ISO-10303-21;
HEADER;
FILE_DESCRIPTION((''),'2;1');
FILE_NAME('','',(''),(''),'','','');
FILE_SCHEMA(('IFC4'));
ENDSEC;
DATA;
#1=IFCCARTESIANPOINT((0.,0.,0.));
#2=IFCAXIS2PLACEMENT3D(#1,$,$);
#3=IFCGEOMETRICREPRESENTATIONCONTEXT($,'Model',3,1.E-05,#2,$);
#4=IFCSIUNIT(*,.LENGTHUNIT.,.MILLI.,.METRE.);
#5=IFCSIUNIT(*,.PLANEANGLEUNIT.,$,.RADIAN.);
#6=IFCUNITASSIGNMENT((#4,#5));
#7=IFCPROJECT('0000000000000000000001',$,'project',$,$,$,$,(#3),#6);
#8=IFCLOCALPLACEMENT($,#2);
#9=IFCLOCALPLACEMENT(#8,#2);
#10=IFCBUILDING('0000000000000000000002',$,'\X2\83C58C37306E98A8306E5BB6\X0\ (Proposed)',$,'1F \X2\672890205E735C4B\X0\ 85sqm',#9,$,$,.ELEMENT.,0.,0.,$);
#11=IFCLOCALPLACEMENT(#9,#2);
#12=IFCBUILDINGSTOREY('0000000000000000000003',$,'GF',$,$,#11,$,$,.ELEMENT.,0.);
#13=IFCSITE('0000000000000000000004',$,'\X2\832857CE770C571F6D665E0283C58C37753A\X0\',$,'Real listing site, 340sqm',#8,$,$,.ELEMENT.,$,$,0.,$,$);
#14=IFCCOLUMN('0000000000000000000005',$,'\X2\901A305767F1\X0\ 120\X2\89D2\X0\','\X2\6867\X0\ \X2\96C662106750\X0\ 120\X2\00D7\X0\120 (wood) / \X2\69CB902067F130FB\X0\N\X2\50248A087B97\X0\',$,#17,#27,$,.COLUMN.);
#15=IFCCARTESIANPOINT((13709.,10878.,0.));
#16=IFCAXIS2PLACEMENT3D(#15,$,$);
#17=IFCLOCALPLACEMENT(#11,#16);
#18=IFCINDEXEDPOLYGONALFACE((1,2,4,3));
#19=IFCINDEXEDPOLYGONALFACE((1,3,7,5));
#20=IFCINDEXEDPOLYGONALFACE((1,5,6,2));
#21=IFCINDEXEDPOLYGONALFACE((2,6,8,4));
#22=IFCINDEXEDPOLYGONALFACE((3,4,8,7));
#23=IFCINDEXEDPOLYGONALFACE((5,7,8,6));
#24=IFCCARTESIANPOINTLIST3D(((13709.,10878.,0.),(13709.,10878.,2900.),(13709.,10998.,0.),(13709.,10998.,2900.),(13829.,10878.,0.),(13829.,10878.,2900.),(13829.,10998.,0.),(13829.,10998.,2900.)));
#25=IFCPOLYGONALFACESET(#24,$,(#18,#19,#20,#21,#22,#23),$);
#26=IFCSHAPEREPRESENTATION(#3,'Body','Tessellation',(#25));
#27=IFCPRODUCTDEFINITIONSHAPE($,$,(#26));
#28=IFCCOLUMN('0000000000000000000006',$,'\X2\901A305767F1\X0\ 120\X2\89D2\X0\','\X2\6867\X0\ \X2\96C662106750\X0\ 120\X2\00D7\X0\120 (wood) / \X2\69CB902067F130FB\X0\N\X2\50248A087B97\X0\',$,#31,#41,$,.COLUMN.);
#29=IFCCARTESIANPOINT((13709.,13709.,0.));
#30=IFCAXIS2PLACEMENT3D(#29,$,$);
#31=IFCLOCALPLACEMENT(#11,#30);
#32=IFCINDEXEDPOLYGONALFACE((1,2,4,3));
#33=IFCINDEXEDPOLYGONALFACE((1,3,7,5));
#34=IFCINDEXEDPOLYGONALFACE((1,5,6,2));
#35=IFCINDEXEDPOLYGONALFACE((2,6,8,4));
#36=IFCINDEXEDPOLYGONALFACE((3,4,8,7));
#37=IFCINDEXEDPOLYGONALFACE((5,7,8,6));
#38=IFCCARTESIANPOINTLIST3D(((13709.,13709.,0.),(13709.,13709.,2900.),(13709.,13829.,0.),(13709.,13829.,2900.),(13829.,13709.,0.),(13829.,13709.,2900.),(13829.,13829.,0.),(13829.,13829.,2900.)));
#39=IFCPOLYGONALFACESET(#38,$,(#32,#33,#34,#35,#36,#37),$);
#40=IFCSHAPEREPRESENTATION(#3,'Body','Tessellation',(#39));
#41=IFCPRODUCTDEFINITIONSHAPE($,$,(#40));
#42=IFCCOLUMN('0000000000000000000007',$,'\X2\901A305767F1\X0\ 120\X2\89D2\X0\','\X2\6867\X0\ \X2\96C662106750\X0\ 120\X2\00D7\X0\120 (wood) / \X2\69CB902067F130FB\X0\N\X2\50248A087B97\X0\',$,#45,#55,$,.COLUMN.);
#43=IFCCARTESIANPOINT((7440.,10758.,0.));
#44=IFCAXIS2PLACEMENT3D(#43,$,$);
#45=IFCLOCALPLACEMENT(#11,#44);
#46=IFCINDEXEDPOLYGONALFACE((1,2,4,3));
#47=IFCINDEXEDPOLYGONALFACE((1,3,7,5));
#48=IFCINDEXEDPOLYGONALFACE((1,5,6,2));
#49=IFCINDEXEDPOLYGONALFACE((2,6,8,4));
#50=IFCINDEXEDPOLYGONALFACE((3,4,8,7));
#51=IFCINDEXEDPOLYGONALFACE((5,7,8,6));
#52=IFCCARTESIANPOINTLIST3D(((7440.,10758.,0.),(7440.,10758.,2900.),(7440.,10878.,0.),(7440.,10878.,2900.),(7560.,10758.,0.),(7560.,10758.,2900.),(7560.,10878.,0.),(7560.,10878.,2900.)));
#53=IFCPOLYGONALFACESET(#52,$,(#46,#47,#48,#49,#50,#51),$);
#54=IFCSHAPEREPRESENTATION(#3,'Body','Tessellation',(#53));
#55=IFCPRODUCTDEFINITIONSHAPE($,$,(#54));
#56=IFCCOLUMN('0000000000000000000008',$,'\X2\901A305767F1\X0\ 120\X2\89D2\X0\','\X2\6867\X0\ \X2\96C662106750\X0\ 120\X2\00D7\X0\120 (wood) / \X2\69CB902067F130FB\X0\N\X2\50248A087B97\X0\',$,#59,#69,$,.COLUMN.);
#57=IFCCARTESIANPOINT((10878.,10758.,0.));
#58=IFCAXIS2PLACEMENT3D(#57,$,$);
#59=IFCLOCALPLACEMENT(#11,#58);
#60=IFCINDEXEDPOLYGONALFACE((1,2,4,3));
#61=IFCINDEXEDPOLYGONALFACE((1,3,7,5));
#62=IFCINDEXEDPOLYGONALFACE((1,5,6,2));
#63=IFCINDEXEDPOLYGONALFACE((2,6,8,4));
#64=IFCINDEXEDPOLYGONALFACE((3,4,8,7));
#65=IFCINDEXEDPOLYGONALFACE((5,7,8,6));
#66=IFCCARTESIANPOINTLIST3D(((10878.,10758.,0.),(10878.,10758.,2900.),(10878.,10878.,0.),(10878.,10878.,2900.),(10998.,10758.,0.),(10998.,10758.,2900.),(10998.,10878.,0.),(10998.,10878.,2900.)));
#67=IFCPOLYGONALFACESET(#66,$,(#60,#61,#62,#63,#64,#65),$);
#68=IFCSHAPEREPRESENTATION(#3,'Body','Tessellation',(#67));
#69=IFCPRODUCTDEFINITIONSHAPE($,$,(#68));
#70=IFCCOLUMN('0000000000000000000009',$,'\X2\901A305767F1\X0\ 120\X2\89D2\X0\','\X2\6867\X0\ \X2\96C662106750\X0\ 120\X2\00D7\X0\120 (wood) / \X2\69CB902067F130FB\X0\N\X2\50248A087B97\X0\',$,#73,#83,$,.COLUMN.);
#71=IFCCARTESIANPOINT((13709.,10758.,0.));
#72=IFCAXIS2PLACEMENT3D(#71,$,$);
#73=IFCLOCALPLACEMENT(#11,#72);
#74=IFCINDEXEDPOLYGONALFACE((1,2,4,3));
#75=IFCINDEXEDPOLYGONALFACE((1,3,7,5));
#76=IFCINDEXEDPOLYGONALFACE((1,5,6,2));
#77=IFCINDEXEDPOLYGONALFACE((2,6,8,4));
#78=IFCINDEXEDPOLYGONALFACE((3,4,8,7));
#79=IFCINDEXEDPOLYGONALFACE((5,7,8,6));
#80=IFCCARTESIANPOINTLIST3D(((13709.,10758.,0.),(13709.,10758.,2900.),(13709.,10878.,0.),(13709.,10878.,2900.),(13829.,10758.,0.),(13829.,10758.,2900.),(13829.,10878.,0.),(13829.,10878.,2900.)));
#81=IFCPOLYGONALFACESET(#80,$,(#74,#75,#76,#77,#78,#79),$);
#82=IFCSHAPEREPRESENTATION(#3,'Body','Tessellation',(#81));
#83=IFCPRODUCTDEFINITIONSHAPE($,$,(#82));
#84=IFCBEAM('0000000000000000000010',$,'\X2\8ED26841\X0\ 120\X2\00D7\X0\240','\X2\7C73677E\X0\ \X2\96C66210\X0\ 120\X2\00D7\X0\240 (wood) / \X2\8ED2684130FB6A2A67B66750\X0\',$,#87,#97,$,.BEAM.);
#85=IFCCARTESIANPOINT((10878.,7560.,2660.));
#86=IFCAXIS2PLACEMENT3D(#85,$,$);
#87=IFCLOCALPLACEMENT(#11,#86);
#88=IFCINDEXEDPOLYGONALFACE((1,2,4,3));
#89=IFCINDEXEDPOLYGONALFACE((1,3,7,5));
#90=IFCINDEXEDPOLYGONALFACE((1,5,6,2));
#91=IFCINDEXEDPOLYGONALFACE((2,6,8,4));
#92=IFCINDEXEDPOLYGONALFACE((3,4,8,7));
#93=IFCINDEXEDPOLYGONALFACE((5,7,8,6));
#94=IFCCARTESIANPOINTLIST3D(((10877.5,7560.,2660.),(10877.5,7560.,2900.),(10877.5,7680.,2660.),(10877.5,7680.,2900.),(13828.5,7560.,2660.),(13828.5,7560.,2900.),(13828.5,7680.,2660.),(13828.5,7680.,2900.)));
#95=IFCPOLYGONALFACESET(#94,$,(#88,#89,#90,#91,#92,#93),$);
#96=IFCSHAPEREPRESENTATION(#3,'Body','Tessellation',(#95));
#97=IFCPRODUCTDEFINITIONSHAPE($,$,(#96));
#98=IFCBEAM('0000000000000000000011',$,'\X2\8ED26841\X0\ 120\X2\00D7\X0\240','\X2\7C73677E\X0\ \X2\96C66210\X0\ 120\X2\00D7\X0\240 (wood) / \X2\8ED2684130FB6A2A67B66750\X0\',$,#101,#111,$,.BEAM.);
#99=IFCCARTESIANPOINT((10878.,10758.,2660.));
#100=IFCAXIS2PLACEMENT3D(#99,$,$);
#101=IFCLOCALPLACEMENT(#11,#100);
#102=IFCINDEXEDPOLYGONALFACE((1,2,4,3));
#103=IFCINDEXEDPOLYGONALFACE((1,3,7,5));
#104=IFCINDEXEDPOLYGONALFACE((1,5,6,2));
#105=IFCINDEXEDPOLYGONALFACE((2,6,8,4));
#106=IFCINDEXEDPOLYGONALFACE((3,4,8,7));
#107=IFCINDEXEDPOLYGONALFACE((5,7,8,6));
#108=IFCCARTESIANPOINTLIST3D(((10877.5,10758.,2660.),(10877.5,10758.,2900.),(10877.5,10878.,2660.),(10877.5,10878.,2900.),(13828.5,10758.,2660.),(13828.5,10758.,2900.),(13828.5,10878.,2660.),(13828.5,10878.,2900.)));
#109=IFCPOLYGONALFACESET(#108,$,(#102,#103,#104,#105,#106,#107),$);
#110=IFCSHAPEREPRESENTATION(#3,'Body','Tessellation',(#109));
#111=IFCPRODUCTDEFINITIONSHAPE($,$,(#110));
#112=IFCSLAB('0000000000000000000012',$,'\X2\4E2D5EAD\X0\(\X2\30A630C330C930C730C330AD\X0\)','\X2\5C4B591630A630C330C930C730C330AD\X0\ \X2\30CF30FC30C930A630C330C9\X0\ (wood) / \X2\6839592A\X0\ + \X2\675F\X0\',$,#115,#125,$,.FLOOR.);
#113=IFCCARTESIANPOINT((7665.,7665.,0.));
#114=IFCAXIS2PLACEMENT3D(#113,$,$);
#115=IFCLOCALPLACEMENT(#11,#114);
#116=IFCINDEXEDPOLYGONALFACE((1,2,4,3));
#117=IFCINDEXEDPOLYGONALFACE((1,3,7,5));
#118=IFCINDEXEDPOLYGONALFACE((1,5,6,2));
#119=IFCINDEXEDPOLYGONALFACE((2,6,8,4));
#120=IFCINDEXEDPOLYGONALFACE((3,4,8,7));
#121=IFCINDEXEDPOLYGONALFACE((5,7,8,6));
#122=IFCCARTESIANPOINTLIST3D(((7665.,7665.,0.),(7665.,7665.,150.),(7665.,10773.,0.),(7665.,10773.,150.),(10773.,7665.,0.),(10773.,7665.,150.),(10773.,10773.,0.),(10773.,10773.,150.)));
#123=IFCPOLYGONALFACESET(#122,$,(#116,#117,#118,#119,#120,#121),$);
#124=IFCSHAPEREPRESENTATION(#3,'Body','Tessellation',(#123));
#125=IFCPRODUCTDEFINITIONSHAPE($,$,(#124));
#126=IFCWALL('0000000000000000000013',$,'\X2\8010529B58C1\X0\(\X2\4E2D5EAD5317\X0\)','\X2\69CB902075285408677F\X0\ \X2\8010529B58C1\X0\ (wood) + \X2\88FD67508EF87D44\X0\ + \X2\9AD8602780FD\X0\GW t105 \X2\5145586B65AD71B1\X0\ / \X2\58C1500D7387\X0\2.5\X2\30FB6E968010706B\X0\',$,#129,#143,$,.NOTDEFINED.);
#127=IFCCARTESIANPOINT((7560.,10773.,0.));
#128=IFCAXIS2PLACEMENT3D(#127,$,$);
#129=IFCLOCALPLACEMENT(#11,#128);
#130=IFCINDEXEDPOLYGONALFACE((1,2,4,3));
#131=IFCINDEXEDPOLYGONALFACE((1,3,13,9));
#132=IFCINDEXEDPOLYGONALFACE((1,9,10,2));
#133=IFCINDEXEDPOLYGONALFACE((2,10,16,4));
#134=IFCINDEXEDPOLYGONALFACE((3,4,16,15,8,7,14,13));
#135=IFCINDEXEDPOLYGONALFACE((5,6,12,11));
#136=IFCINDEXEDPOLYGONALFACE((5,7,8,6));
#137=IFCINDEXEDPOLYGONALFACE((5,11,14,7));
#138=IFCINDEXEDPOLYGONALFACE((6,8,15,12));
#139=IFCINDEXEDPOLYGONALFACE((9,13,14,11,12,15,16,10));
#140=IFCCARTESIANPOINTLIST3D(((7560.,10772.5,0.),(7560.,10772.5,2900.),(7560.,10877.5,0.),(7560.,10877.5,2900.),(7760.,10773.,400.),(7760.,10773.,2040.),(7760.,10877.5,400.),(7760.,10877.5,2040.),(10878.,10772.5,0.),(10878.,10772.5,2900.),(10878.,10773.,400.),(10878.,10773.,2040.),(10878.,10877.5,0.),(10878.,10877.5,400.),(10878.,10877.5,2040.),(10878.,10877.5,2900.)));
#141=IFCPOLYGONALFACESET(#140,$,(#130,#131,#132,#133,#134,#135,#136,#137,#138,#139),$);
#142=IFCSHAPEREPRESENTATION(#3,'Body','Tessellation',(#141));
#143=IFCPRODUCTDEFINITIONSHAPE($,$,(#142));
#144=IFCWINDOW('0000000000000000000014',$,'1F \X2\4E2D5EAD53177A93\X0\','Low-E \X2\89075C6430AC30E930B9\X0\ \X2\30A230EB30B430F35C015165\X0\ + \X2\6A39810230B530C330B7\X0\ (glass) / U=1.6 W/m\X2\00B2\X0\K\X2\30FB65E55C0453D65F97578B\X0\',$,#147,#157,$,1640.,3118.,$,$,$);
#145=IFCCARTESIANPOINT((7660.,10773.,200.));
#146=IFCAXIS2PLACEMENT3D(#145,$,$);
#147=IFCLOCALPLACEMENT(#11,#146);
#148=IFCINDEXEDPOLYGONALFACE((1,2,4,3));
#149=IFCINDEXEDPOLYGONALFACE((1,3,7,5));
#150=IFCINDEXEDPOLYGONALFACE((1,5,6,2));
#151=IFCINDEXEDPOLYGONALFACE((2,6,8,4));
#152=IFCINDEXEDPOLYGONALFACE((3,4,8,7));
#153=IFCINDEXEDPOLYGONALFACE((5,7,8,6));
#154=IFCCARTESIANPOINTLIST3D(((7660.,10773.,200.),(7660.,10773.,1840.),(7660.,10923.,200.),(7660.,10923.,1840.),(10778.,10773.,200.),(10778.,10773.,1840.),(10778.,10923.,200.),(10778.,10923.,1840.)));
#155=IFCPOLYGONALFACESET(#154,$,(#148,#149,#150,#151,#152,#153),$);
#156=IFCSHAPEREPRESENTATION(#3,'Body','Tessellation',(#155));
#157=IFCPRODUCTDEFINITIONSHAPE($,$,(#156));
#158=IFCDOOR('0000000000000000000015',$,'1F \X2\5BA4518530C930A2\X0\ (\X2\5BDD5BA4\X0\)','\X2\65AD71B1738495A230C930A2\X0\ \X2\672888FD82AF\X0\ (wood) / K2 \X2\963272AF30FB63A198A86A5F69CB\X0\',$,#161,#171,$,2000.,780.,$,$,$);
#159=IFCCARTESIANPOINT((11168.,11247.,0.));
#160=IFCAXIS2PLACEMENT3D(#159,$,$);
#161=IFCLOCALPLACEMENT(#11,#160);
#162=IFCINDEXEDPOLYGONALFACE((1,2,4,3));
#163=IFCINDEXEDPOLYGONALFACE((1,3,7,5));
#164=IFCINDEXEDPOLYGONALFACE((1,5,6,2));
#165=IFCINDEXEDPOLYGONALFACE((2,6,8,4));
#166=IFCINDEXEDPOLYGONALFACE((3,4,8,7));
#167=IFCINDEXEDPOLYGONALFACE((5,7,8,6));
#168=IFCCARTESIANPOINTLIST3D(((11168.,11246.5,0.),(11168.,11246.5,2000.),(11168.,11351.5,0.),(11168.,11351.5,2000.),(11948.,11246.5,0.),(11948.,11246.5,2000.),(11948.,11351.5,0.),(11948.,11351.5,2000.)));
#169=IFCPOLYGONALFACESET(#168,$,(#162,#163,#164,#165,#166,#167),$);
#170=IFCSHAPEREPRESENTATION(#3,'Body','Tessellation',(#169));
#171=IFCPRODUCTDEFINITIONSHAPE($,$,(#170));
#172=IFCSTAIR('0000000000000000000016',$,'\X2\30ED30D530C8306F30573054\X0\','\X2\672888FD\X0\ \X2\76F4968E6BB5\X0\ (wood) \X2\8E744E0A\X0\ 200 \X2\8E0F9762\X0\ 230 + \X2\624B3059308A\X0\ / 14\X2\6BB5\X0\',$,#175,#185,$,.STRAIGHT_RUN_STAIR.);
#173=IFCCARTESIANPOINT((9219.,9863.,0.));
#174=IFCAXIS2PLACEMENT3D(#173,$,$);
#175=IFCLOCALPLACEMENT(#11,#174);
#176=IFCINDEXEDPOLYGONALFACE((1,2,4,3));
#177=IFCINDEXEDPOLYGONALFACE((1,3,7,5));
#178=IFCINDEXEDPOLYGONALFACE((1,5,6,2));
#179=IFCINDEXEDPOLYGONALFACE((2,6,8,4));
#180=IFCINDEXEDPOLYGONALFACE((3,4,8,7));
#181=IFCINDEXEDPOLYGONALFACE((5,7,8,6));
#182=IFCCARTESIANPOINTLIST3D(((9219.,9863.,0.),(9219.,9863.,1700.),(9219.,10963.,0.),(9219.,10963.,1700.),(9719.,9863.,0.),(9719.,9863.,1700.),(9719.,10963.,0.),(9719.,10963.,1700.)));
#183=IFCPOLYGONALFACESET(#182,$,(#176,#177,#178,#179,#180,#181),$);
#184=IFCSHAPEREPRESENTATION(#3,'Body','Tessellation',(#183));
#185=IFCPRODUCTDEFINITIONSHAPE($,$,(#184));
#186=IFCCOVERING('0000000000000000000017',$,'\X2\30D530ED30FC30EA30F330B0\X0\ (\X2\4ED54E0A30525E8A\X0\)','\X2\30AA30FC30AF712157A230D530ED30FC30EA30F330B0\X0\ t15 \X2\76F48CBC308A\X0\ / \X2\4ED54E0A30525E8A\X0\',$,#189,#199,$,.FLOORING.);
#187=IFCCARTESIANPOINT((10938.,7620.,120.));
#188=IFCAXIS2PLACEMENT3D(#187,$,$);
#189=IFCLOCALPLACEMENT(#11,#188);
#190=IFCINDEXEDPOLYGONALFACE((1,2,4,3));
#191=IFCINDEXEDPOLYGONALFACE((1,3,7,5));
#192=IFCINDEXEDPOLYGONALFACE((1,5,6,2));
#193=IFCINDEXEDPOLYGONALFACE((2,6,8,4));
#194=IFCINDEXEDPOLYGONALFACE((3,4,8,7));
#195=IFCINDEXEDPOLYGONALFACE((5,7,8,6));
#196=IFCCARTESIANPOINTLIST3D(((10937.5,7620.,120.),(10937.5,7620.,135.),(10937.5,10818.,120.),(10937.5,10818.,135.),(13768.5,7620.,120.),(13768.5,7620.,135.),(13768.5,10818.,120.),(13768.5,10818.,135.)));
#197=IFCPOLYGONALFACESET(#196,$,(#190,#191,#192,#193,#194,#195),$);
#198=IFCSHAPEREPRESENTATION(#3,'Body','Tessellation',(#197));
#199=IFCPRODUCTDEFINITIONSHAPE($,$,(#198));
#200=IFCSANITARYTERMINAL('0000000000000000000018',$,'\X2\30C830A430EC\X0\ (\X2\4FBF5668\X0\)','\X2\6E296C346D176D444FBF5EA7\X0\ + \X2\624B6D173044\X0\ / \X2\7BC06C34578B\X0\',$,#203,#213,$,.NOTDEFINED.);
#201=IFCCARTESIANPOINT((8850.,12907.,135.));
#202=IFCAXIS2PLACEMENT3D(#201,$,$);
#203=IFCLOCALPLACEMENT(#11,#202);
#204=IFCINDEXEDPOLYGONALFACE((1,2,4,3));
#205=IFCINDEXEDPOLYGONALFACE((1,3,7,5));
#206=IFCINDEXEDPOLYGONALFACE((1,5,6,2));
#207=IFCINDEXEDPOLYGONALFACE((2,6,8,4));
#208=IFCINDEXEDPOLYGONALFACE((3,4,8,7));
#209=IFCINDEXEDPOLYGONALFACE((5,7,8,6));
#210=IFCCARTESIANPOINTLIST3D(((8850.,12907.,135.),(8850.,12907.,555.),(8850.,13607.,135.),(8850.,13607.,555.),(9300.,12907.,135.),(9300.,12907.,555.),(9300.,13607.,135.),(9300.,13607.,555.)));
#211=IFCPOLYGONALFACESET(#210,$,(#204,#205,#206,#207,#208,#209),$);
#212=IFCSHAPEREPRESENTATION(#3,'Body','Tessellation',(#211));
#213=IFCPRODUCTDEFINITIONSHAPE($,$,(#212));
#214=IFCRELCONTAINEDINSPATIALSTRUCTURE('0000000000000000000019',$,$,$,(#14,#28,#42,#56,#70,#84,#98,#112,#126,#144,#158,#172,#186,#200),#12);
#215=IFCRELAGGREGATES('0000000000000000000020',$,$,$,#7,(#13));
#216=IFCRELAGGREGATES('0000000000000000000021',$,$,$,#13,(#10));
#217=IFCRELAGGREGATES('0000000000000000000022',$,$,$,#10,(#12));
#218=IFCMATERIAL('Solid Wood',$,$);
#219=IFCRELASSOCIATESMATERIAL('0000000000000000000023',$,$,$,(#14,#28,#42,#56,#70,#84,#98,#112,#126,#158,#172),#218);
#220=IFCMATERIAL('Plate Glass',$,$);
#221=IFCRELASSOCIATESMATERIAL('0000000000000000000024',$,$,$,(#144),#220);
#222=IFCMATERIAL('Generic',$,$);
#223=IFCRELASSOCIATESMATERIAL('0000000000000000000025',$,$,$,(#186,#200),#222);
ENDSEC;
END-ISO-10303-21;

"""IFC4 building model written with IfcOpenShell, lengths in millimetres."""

from ifc_helpers import new_model, si_unit, frame, frame_2d, origin, place, context, project, spatial, rectangle, extrude, material, element, fill, save


model = new_model("IFC4")

# Units and contexts
model_context = context("Model", 3, precision=1e-05, world=origin())
ifc_project = project(units=[si_unit("LENGTHUNIT", "METRE", prefix="MILLI"), si_unit("PLANEANGLEUNIT", "RADIAN")], contexts=[model_context])

# Site, building, storey
site_placement = place(None, origin())
site = spatial("IfcSite", under=ifc_project, at=site_placement, Name="茨城県土浦市菅谷町", ObjectType="Real listing site, 340sqm", CompositionType="ELEMENT", RefElevation=0.0)
building_placement = place(site_placement, origin())
building = spatial("IfcBuilding", under=site, at=building_placement, Name="菅谷の風の家 (Proposed)", ObjectType="1F 木造平屋 85sqm", CompositionType="ELEMENT", ElevationOfRefHeight=0.0, ElevationOfTerrain=0.0)
storey_placement = place(building_placement, origin())
storey = spatial("IfcBuildingStorey", under=building, at=storey_placement, Name="GF", CompositionType="ELEMENT", Elevation=0.0)

# Columns
ifc_material_1 = material(Name="Solid Wood")
column_1_placement = place(storey_placement, frame((13709.0, 10878.0, 0.0)))
element("IfcColumn", 1, at=column_1_placement, inside=storey, material=ifc_material_1, Name="通し柱 120角", Description="桧 集成材 120×120 (wood) / 構造柱・N値計算", PredefinedType="COLUMN", context=model_context, shape_type="SweptSolid", body=[
    extrude(rectangle(XDim=120.0, YDim=120.0, at=frame_2d((60.0, 60.0))), frame((13709.0, 10878.0, 0.0)), (0.0, 0.0, 1.0), 2900.0),
])
column_2_placement = place(storey_placement, frame((13709.0, 13709.0, 0.0)))
element("IfcColumn", 2, at=column_2_placement, inside=storey, material=ifc_material_1, Name="通し柱 120角", Description="桧 集成材 120×120 (wood) / 構造柱・N値計算", PredefinedType="COLUMN", context=model_context, shape_type="SweptSolid", body=[
    extrude(rectangle(XDim=120.0, YDim=120.0, at=frame_2d((60.0, 60.0))), frame((13709.0, 13709.0, 0.0)), (0.0, 0.0, 1.0), 2900.0),
])
column_3_placement = place(storey_placement, frame((7440.0, 10758.0, 0.0)))
element("IfcColumn", 3, at=column_3_placement, inside=storey, material=ifc_material_1, Name="通し柱 120角", Description="桧 集成材 120×120 (wood) / 構造柱・N値計算", PredefinedType="COLUMN", context=model_context, shape_type="SweptSolid", body=[
    extrude(rectangle(XDim=120.0, YDim=120.0, at=frame_2d((60.0, 60.0))), frame((7440.0, 10758.0, 0.0)), (0.0, 0.0, 1.0), 2900.0),
])
column_4_placement = place(storey_placement, frame((10878.0, 10758.0, 0.0)))
element("IfcColumn", 4, at=column_4_placement, inside=storey, material=ifc_material_1, Name="通し柱 120角", Description="桧 集成材 120×120 (wood) / 構造柱・N値計算", PredefinedType="COLUMN", context=model_context, shape_type="SweptSolid", body=[
    extrude(rectangle(XDim=120.0, YDim=120.0, at=frame_2d((60.0, 60.0))), frame((10878.0, 10758.0, 0.0)), (0.0, 0.0, 1.0), 2900.0),
])
column_5_placement = place(storey_placement, frame((13709.0, 10758.0, 0.0)))
element("IfcColumn", 5, at=column_5_placement, inside=storey, material=ifc_material_1, Name="通し柱 120角", Description="桧 集成材 120×120 (wood) / 構造柱・N値計算", PredefinedType="COLUMN", context=model_context, shape_type="SweptSolid", body=[
    extrude(rectangle(XDim=120.0, YDim=120.0, at=frame_2d((60.0, 60.0))), frame((13709.0, 10758.0, 0.0)), (0.0, 0.0, 1.0), 2900.0),
])

# Beams
beam_1_placement = place(storey_placement, frame((10878.0, 7560.0, 2660.0)))
element("IfcBeam", 6, at=beam_1_placement, inside=storey, material=ifc_material_1, Name="軒桁 120×240", Description="米松 集成 120×240 (wood) / 軒桁・横架材", PredefinedType="BEAM", context=model_context, shape_type="SweptSolid", body=[
    extrude(rectangle(XDim=2951.0, YDim=120.0, at=frame_2d((1475.0, 60.0))), frame((10878.0, 7560.0, 2660.0)), (0.0, 0.0, 1.0), 240.0),
])
beam_2_placement = place(storey_placement, frame((10878.0, 10758.0, 2660.0)))
element("IfcBeam", 7, at=beam_2_placement, inside=storey, material=ifc_material_1, Name="軒桁 120×240", Description="米松 集成 120×240 (wood) / 軒桁・横架材", PredefinedType="BEAM", context=model_context, shape_type="SweptSolid", body=[
    extrude(rectangle(XDim=2951.0, YDim=120.0, at=frame_2d((1475.0, 60.0))), frame((10878.0, 10758.0, 2660.0)), (0.0, 0.0, 1.0), 240.0),
])

# Slab
slab_placement = place(storey_placement, frame((7665.0, 7665.0, 0.0)))
element("IfcSlab", 8, at=slab_placement, inside=storey, material=ifc_material_1, Name="中庭(ウッドデッキ)", Description="屋外ウッドデッキ ハードウッド (wood) / 根太 + 束", PredefinedType="FLOOR", context=model_context, shape_type="SweptSolid", body=[
    extrude(rectangle(XDim=3108.0, YDim=3108.0, at=frame_2d((1554.0, 1554.0))), frame((7665.0, 7665.0, 0.0)), (0.0, 0.0, 1.0), 150.0),
])

# Wall, opening, window
wall_1_placement = place(storey_placement, frame((7560.0, 10773.0, 0.0)))
wall_1 = element("IfcWall", 9, at=wall_1_placement, inside=storey, material=ifc_material_1, Name="耐力壁(中庭北)", Description="構造用合板 耐力壁 (wood) + 製材軸組 + 高性能GW t105 充填断熱 / 壁倍率2.5・準耐火", PredefinedType="NOTDEFINED", context=model_context, shape_type="SweptSolid", body=[
    extrude(rectangle(XDim=3318.0, YDim=105.0, at=frame_2d((1659.0, 52.0))), frame((7560.0, 10773.0, 0.0)), (0.0, 0.0, 1.0), 2900.0),
])
opening_placement = place(storey_placement, frame((7660.0, 10773.0, 200.0)))
opening = element("IfcOpeningElement", 10, at=opening_placement, cuts=wall_1, PredefinedType="NOTDEFINED", context=model_context, shape_type="SweptSolid", body=[
    extrude(rectangle(XDim=3118.0, YDim=150.0, at=frame_2d((1559.0, 75.0))), frame((7660.0, 10773.0, 200.0)), (0.0, 0.0, 1.0), 1640.0),
])
ifc_material_2 = material(Name="Plate Glass")
window_placement = place(storey_placement, frame((7660.0, 10773.0, 200.0)))
window = element("IfcWindow", 11, at=window_placement, inside=storey, material=ifc_material_2, Name="1F 中庭北窓", Description="Low-E 複層ガラス アルゴン封入 + 樹脂サッシ (glass) / U=1.6 W/m²K・日射取得型", OverallHeight=1640.0, OverallWidth=3118.0, context=model_context, shape_type="SweptSolid", body=[
    extrude(rectangle(XDim=3118.0, YDim=150.0, at=frame_2d((1559.0, 75.0))), frame((7660.0, 10773.0, 200.0)), (0.0, 0.0, 1.0), 1640.0),
])
fill(opening, window)

# Door
door_placement = place(storey_placement, frame((11168.0, 11247.0, 0.0)))
element("IfcDoor", 12, at=door_placement, inside=storey, material=ifc_material_1, Name="1F 室内ドア (寝室)", Description="断熱玄関ドア 木製芯 (wood) / K2 防犯・採風機構", OverallHeight=2000.0, OverallWidth=780.0, context=model_context, shape_type="SweptSolid", body=[
    extrude(rectangle(XDim=780.0, YDim=105.0, at=frame_2d((390.0, 52.0))), frame((11168.0, 11247.0, 0.0)), (0.0, 0.0, 1.0), 2000.0),
])

# Stair
stair_placement = place(storey_placement, frame((9219.0, 9863.0, 0.0)))
element("IfcStair", 13, at=stair_placement, inside=storey, material=ifc_material_1, Name="ロフトはしご", Description="木製 直階段 (wood) 蹴上 200 踏面 230 + 手すり / 14段", PredefinedType="STRAIGHT_RUN_STAIR", context=model_context, shape_type="SweptSolid", body=[
    extrude(rectangle(XDim=500.0, YDim=1100.0, at=frame_2d((250.0, 550.0))), frame((9219.0, 9863.0, 0.0)), (0.0, 0.0, 1.0), 1700.0),
])

# Covering
ifc_material_3 = material(Name="Generic")
covering_placement = place(storey_placement, frame((10938.0, 7620.0, 120.0)))
element("IfcCovering", 14, at=covering_placement, inside=storey, material=ifc_material_3, Name="フローリング (仕上げ床)", Description="オーク無垢フローリング t15 直貼り / 仕上げ床", PredefinedType="FLOORING", context=model_context, shape_type="SweptSolid", body=[
    extrude(rectangle(XDim=2831.0, YDim=3198.0, at=frame_2d((1415.0, 1599.0))), frame((10938.0, 7620.0, 120.0)), (0.0, 0.0, 1.0), 15.0),
])

# Sanitary terminal
sanitary_terminal_placement = place(storey_placement, frame((8850.0, 12907.0, 135.0)))
element("IfcSanitaryTerminal", 15, at=sanitary_terminal_placement, inside=storey, material=ifc_material_3, Name="トイレ (便器)", Description="温水洗浄便座 + 手洗い / 節水型", PredefinedType="NOTDEFINED", context=model_context, shape_type="SweptSolid", body=[
    extrude(rectangle(XDim=450.0, YDim=700.0, at=frame_2d((225.0, 350.0))), frame((8850.0, 12907.0, 135.0)), (0.0, 0.0, 1.0), 420.0),
])

save(model, "model.ifc")
